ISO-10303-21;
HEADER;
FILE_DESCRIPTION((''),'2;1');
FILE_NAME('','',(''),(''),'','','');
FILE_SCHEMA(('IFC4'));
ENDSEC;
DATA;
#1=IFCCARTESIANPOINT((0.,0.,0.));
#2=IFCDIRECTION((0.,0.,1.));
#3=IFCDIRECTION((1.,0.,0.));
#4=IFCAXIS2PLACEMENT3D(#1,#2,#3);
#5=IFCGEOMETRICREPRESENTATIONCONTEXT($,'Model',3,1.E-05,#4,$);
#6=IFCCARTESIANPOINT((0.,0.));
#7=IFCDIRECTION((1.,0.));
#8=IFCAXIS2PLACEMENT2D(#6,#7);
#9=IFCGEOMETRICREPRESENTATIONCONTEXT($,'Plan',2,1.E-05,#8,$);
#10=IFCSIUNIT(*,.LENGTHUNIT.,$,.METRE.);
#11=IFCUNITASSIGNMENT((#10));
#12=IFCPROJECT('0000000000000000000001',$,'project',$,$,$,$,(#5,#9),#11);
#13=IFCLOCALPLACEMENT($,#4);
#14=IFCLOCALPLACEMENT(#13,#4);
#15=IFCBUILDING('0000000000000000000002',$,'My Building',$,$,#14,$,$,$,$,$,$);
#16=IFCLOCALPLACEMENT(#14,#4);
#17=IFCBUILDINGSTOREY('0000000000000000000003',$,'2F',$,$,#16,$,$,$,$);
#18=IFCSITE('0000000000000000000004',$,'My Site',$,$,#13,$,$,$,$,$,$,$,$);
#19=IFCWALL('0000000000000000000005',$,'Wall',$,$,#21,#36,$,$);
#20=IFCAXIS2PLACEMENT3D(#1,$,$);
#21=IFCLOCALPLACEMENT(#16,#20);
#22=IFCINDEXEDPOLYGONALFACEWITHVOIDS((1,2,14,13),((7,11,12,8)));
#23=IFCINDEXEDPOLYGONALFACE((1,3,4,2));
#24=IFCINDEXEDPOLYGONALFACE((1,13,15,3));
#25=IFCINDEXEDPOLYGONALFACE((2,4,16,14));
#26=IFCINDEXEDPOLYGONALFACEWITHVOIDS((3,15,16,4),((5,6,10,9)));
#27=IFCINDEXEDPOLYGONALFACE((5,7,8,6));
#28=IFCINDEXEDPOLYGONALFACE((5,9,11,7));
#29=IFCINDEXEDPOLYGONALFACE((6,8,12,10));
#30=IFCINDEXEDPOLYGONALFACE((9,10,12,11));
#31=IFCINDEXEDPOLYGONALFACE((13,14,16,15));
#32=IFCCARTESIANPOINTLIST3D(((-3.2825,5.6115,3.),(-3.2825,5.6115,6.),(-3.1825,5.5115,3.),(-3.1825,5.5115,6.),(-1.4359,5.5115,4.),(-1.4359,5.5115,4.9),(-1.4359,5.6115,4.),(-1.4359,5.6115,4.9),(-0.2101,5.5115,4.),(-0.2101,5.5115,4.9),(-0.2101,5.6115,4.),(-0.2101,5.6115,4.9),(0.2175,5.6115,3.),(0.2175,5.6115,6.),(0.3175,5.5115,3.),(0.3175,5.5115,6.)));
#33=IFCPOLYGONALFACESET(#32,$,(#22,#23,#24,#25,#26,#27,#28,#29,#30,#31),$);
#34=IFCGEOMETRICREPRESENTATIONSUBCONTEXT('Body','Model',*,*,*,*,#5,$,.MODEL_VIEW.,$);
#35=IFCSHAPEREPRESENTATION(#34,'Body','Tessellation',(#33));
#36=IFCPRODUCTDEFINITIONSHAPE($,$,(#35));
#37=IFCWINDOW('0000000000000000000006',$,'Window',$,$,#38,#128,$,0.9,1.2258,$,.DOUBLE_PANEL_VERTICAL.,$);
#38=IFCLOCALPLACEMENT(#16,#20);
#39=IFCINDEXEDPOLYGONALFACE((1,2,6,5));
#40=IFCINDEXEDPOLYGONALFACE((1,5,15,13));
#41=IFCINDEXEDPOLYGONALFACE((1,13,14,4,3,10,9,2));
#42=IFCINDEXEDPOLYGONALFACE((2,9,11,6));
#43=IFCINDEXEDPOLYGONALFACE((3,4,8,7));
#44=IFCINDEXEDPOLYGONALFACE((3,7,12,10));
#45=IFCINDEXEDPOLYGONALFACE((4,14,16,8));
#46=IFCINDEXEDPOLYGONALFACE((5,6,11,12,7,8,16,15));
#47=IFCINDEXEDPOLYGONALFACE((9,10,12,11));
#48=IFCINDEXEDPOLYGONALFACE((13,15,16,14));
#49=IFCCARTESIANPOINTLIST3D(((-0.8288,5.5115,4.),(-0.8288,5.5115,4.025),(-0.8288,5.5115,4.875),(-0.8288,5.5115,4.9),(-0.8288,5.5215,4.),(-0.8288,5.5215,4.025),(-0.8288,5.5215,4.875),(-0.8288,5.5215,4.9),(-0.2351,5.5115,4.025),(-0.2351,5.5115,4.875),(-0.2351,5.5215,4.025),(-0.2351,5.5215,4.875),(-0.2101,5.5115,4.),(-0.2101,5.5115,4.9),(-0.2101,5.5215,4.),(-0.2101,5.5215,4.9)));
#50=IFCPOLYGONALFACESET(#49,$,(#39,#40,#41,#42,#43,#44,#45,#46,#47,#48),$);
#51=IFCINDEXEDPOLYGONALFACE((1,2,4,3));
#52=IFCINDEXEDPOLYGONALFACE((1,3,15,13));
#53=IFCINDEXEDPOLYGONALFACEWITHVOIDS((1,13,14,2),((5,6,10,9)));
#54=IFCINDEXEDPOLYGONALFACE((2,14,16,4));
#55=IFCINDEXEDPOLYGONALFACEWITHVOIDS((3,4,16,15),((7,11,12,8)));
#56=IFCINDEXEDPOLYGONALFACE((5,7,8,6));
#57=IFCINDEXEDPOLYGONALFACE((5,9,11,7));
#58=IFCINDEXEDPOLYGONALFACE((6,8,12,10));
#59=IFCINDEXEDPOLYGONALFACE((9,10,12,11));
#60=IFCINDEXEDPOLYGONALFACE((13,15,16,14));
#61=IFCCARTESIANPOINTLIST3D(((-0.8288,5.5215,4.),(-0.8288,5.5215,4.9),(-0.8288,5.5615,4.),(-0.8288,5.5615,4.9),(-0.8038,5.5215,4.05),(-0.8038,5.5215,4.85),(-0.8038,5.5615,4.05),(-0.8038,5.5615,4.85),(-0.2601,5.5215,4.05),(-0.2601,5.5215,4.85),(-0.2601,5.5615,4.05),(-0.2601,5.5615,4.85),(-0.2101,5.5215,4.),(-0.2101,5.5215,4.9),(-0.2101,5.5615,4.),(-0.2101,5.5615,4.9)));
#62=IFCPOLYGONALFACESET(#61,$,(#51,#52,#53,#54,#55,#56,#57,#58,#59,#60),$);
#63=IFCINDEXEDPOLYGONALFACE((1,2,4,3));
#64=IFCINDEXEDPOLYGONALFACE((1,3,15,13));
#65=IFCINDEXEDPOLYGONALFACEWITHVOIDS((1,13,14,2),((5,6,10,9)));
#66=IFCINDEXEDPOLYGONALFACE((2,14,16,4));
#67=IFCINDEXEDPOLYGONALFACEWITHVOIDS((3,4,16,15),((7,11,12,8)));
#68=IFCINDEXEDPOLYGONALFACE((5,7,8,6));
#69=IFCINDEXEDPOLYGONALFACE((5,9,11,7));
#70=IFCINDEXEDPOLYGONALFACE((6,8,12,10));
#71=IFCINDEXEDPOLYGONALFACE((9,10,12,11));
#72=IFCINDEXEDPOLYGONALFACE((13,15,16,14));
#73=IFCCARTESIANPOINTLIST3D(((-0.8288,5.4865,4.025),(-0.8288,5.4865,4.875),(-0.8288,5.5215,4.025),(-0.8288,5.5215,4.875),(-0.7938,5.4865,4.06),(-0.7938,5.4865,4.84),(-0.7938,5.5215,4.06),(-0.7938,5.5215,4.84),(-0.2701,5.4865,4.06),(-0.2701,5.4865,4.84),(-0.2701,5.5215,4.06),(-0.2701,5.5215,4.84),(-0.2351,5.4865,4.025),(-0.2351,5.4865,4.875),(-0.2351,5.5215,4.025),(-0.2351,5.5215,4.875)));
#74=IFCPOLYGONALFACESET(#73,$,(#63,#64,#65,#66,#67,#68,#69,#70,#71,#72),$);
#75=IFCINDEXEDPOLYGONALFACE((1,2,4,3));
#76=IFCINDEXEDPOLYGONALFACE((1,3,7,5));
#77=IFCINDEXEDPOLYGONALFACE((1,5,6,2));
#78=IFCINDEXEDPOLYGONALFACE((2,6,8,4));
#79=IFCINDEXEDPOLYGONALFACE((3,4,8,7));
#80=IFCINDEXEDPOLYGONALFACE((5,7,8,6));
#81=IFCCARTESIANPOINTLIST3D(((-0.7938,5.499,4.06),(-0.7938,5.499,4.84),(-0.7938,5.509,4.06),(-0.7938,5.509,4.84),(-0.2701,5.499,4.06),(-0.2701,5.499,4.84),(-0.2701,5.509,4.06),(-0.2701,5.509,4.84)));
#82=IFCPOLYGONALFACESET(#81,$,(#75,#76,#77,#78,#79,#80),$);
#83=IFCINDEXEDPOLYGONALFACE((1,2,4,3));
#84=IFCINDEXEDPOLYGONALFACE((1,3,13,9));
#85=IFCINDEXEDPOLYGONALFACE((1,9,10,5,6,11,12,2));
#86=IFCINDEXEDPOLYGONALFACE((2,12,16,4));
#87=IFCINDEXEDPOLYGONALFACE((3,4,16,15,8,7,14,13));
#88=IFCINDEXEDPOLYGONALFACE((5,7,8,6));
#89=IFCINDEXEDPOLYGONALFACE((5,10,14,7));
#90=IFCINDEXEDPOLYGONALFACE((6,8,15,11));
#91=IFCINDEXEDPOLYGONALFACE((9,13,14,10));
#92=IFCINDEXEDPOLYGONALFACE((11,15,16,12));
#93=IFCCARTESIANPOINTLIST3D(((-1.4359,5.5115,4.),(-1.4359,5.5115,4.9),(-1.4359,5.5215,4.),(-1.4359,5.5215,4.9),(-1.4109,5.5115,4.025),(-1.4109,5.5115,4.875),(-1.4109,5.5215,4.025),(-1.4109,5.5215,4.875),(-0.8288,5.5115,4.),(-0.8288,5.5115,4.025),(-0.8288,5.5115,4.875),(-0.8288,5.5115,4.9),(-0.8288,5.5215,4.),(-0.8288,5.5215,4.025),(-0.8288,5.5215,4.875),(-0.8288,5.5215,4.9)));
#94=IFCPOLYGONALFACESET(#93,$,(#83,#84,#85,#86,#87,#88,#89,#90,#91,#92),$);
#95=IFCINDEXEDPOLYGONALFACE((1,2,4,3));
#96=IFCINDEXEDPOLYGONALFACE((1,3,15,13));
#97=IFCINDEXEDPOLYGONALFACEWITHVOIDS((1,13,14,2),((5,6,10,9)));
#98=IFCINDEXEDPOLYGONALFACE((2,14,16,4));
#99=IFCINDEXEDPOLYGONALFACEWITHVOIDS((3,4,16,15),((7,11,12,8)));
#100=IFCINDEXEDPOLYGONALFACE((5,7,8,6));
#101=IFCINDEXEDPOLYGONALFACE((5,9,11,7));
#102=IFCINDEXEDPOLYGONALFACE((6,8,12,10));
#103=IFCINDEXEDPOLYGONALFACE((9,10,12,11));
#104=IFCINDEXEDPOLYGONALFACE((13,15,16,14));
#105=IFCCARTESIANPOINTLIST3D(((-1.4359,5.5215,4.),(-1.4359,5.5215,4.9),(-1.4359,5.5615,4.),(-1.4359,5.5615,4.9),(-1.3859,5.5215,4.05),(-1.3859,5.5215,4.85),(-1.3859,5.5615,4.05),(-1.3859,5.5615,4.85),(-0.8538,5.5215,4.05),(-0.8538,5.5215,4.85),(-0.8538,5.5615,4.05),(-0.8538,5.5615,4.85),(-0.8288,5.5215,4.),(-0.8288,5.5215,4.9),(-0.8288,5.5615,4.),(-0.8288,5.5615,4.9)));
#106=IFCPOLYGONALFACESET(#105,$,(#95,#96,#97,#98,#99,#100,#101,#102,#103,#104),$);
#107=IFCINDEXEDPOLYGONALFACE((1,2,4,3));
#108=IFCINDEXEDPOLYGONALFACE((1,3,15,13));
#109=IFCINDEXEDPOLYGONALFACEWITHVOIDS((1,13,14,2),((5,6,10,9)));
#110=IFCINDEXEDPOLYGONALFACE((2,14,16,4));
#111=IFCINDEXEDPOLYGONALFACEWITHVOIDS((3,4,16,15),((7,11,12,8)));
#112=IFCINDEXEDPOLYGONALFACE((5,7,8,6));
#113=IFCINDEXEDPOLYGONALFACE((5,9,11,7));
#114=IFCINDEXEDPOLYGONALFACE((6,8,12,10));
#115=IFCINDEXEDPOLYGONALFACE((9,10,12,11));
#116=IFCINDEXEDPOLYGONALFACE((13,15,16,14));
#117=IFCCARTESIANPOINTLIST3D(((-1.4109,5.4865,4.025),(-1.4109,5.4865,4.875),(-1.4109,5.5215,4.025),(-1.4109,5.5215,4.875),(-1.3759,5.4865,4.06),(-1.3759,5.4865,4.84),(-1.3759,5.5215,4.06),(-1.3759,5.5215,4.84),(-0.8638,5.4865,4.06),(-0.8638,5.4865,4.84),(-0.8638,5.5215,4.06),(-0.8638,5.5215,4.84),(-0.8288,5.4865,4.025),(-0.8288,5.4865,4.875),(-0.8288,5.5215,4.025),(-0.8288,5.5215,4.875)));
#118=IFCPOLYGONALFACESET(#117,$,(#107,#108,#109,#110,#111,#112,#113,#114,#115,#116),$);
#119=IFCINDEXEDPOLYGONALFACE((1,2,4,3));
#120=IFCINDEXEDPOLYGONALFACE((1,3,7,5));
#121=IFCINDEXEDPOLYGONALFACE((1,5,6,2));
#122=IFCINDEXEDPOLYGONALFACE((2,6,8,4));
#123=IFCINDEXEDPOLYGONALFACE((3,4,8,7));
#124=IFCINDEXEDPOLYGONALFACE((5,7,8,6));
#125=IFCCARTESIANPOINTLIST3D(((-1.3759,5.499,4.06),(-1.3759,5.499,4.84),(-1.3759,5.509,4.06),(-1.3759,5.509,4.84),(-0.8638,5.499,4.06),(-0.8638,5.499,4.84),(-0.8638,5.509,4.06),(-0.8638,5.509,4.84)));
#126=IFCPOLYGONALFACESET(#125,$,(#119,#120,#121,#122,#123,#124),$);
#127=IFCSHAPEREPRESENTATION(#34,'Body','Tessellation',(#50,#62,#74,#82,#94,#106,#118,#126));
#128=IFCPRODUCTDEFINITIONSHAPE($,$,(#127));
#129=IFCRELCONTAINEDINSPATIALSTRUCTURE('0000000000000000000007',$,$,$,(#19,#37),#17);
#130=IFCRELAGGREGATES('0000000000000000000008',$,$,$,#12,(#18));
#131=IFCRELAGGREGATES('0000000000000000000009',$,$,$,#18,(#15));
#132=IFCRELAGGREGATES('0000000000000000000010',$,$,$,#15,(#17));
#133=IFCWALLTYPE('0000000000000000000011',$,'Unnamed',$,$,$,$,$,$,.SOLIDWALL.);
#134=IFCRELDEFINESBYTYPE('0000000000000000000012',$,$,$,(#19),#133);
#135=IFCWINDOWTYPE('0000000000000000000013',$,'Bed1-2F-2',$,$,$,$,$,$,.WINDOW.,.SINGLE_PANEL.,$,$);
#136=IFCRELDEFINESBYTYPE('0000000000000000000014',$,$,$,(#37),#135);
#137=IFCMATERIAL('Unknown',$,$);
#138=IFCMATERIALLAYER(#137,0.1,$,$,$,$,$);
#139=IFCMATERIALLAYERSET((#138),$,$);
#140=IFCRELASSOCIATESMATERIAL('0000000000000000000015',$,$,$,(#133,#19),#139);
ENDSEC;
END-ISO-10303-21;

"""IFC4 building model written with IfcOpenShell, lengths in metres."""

from ifc_helpers import new_model, entity, si_unit, frame, origin_with_axes, origin_2d_with_axis, place, context, subcontext, project, spatial, line, indexed_curve, outline, extrude, shape, source, transform, mapped, material, layer, layer_set, layer_usage, type_object, type_shapes, element, fill, save


model = new_model("IFC4")

# Units and contexts
model_context = context("Model", 3, precision=1e-05, world=origin_with_axes())
plan_context = context("Plan", 2, precision=1e-05, world=origin_2d_with_axis())
body_context_1 = subcontext(model_context, "Body", "Model", "MODEL_VIEW")
body_context_2 = subcontext(plan_context, "Body", "Plan", "PLAN_VIEW")
ifc_project = project(units=[si_unit("LENGTHUNIT", "METRE")], contexts=[model_context, plan_context])

# Site, building, storey
site_placement = place(None, origin_with_axes())
site = spatial("IfcSite", under=ifc_project, at=site_placement, Name="My Site")
building_placement = place(site_placement, origin_with_axes())
building = spatial("IfcBuilding", under=site, at=building_placement, Name="My Building")
storey_placement = place(building_placement, origin_with_axes())
storey = spatial("IfcBuildingStorey", under=building, at=storey_placement, Name="2F")

# Shared definitions
ifc_material = material(Name="Unknown")

# Shared definitions
ifc_layer = layer(ifc_material, 0.1)
ifc_layer_set = layer_set([ifc_layer])
wall_type = type_object("IfcWallType", Name="Unnamed", PredefinedType="SOLIDWALL", material=ifc_layer_set)

# Wall, opening, window
ifc_layer_usage_1 = layer_usage(ifc_layer_set, "AXIS2", "POSITIVE", 0.0)
wall_1_placement = place(storey_placement, frame((-3.1825, 5.5115, 3.0), z_axis=(0.0, 0.0, 1.0), x_axis=(1.0, 0.0, 0.0)))
wall_1 = element("IfcWall", 1, at=wall_1_placement, inside=storey, type_object=wall_type, material=ifc_layer_usage_1, Name="Wall", context=body_context_1, shape_type="SweptSolid", body=[
    extrude(outline(indexed_curve([(0.0, 0.0), (-0.1, 0.1), (3.4, 0.1), (3.5, 0.0)], segments=[line(1, 2, 3, 4, 1)])), origin_with_axes(), (0.0, 0.0, 1.0), 3.0),
])
shared_shape_1 = source(origin_with_axes(), body_context_1, "Body", "SweptSolid", [
    extrude(outline(indexed_curve([(0.0, 0.0), (1.2258, 0.0), (1.2258, 0.9), (0.0, 0.9)], segments=[line(1, 2, 3, 4, 1)])), frame((0.0, -0.6, 0.0), z_axis=(0.0, -1.0, 0.0), x_axis=(1.0, 0.0, 0.0)), (0.0, 0.0, -1.0), 1.2),
])
opening_1_placement = place(wall_1_placement, frame((2.9724, 0.1, 1.0), z_axis=(0.0, 0.0, 1.0), x_axis=(-1.0, 0.0, 0.0)))
opening_1 = element("IfcOpeningElement", 2, at=opening_1_placement, cuts=wall_1, PredefinedType="OPENING", context=body_context_1, shape_type="MappedRepresentation", body=[
    mapped(shared_shape_1, transform((0.0, 0.0, 0.0), x_axis=(1.0, 0.0, 0.0), y_axis=(0.0, 1.0, 0.0), z_axis=(0.0, 0.0, 1.0), scale=1.0)),
])
window_type = type_object("IfcWindowType", Name="Bed1-2F-2", PartitioningType="SINGLE_PANEL", PredefinedType="WINDOW")
shared_shape_2 = source(origin_with_axes(), body_context_1, "Body", "SweptSolid", [
    extrude(outline(indexed_curve([(0.6187, 0.0), (0.0, 0.0), (0.0, 0.9), (0.6187, 0.9), (0.6187, 0.875), (0.025, 0.875), (0.025, 0.025), (0.6187, 0.025)], segments=[line(1, 2, 3, 4, 5, 6, 7, 8, 1)])), frame((0.0, 0.09, 0.0), z_axis=(0.0, -1.0, 0.0), x_axis=(1.0, 0.0, 0.0)), (0.0, 0.0, -1.0), 0.01),
    extrude(outline(indexed_curve([(0.0, 0.0), (0.6187, 0.0), (0.6187, 0.9), (0.0, 0.9)], segments=[line(1, 2, 3, 4, 1)]), holes=[indexed_curve([(0.05, 0.05), (0.5937, 0.05), (0.5937, 0.85), (0.05, 0.85)], segments=[line(1, 2, 3, 4, 1)])]), frame((0.0, 0.05, 0.0), z_axis=(0.0, -1.0, 0.0), x_axis=(1.0, 0.0, 0.0)), (0.0, 0.0, -1.0), 0.04),
    extrude(outline(indexed_curve([(0.0, 0.0), (0.5937, 0.0), (0.5937, 0.85), (0.0, 0.85)], segments=[line(1, 2, 3, 4, 1)]), holes=[indexed_curve([(0.035, 0.035), (0.5587, 0.035), (0.5587, 0.815), (0.035, 0.815)], segments=[line(1, 2, 3, 4, 1)])]), frame((0.025, 0.09, 0.025), z_axis=(0.0, -1.0, 0.0), x_axis=(1.0, 0.0, 0.0)), (0.0, 0.0, -1.0), 0.035),
    extrude(outline(indexed_curve([(0.035, 0.035), (0.5587, 0.035), (0.5587, 0.815), (0.035, 0.815)], segments=[line(1, 2, 3, 4, 1)])), frame((0.025, 0.1025, 0.025), z_axis=(0.0, -1.0, 0.0), x_axis=(1.0, 0.0, 0.0)), (0.0, 0.0, -1.0), 0.01),
    extrude(outline(indexed_curve([(0.0, 0.9), (0.6071, 0.9), (0.6071, 0.0), (0.0, 0.0), (0.0, 0.025), (0.5821, 0.025), (0.5821, 0.875), (0.0, 0.875)], segments=[line(1, 2, 3, 4, 5, 6, 7, 8, 1)])), frame((0.6187, 0.09, 0.0), z_axis=(0.0, -1.0, 0.0), x_axis=(1.0, 0.0, 0.0)), (0.0, 0.0, -1.0), 0.01),
    extrude(outline(indexed_curve([(0.0, 0.0), (0.6071, 0.0), (0.6071, 0.9), (0.0, 0.9)], segments=[line(1, 2, 3, 4, 1)]), holes=[indexed_curve([(0.025, 0.05), (0.5571, 0.05), (0.5571, 0.85), (0.025, 0.85)], segments=[line(1, 2, 3, 4, 1)])]), frame((0.6187, 0.05, 0.0), z_axis=(0.0, -1.0, 0.0), x_axis=(1.0, 0.0, 0.0)), (0.0, 0.0, -1.0), 0.04),
    extrude(outline(indexed_curve([(0.0, 0.0), (0.5821, 0.0), (0.5821, 0.85), (0.0, 0.85)], segments=[line(1, 2, 3, 4, 1)]), holes=[indexed_curve([(0.035, 0.035), (0.5471, 0.035), (0.5471, 0.815), (0.035, 0.815)], segments=[line(1, 2, 3, 4, 1)])]), frame((0.6187, 0.09, 0.025), z_axis=(0.0, -1.0, 0.0), x_axis=(1.0, 0.0, 0.0)), (0.0, 0.0, -1.0), 0.035),
    extrude(outline(indexed_curve([(0.035, 0.035), (0.5471, 0.035), (0.5471, 0.815), (0.035, 0.815)], segments=[line(1, 2, 3, 4, 1)])), frame((0.6187, 0.1025, 0.025), z_axis=(0.0, -1.0, 0.0), x_axis=(1.0, 0.0, 0.0)), (0.0, 0.0, -1.0), 0.01),
])
shared_shape_3 = source(origin_with_axes(), body_context_2, "Body", "Curve2D", [
    entity("IfcIndexedPolyCurve", entity("IfcCartesianPointList2D", [[0.05, 0.05], [0.5937, 0.05]])),
    entity("IfcIndexedPolyCurve", entity("IfcCartesianPointList2D", [[0.0, 0.1], [0.025, 0.1], [0.025, 0.09], [0.05, 0.09], [0.05, 0.05], [0.0, 0.05]]), [entity("IfcLineIndex", [1, 2, 3, 4, 5, 6, 1])]),
    entity("IfcIndexedPolyCurve", entity("IfcCartesianPointList2D", [[0.6187, 0.1], [0.6187, 0.1], [0.6187, 0.09], [0.5937, 0.09], [0.5937, 0.05], [0.6187, 0.05]])),
    entity("IfcIndexedPolyCurve", entity("IfcCartesianPointList2D", [[0.025, 0.09], [0.06, 0.09], [0.06, 0.125], [0.025, 0.125]]), [entity("IfcLineIndex", [1, 2, 3, 4, 1])]),
    entity("IfcIndexedPolyCurve", entity("IfcCartesianPointList2D", [[0.6187, 0.09], [0.5837, 0.09], [0.5837, 0.125], [0.6187, 0.125]]), [entity("IfcLineIndex", [1, 2, 3, 4, 1])]),
    entity("IfcIndexedPolyCurve", entity("IfcCartesianPointList2D", [[0.06, 0.09], [0.5837, 0.09]])),
    entity("IfcIndexedPolyCurve", entity("IfcCartesianPointList2D", [[0.06, 0.125], [0.5837, 0.125]])),
    entity("IfcIndexedPolyCurve", entity("IfcCartesianPointList2D", [[0.06, 0.1075], [0.5837, 0.1075]])),
    entity("IfcIndexedPolyCurve", entity("IfcCartesianPointList2D", [[0.6437, 0.05], [1.1758, 0.05]])),
    entity("IfcIndexedPolyCurve", entity("IfcCartesianPointList2D", [[0.6187, 0.1], [0.6187, 0.1], [0.6187, 0.09], [0.6437, 0.09], [0.6437, 0.05], [0.6187, 0.05]])),
    entity("IfcIndexedPolyCurve", entity("IfcCartesianPointList2D", [[1.2258, 0.1], [1.2008, 0.1], [1.2008, 0.09], [1.1758, 0.09], [1.1758, 0.05], [1.2258, 0.05]]), [entity("IfcLineIndex", [1, 2, 3, 4, 5, 6, 1])]),
    entity("IfcIndexedPolyCurve", entity("IfcCartesianPointList2D", [[0.6187, 0.09], [0.6537, 0.09], [0.6537, 0.125], [0.6187, 0.125]]), [entity("IfcLineIndex", [1, 2, 3, 4, 1])]),
    entity("IfcIndexedPolyCurve", entity("IfcCartesianPointList2D", [[1.2008, 0.09], [1.1658, 0.09], [1.1658, 0.125], [1.2008, 0.125]]), [entity("IfcLineIndex", [1, 2, 3, 4, 1])]),
    entity("IfcIndexedPolyCurve", entity("IfcCartesianPointList2D", [[0.6537, 0.09], [1.1658, 0.09]])),
    entity("IfcIndexedPolyCurve", entity("IfcCartesianPointList2D", [[0.6537, 0.125], [1.1658, 0.125]])),
    entity("IfcIndexedPolyCurve", entity("IfcCartesianPointList2D", [[0.6537, 0.1075], [1.1658, 0.1075]])),
])
type_shapes(window_type, [shared_shape_2, shared_shape_3])
window_placement = place(opening_1_placement, frame((0.0, 0.0, 0.0), z_axis=(0.0, 0.0, 1.0), x_axis=(1.0, 0.0, 0.0)))
window = element("IfcWindow", 3, at=window_placement, inside=storey, type_object=window_type, Name="Window", OverallHeight=0.9, OverallWidth=1.2258, PartitioningType="DOUBLE_PANEL_VERTICAL", shapes=[
    shape(body_context_1, "Body", "MappedRepresentation", [mapped(shared_shape_2, transform((0.0, 0.0, 0.0), x_axis=(1.0, 0.0, 0.0), y_axis=(0.0, 1.0, 0.0), z_axis=(0.0, 0.0, 1.0), scale=1.0))]),
    shape(body_context_2, "Body", "MappedRepresentation", [mapped(shared_shape_3, transform((0.0, 0.0, 0.0), x_axis=(1.0, 0.0, 0.0), y_axis=(0.0, 1.0, 0.0), z_axis=(0.0, 0.0, 1.0), scale=1.0))]),
])
fill(opening_1, window)

save(model, "model.ifc")
